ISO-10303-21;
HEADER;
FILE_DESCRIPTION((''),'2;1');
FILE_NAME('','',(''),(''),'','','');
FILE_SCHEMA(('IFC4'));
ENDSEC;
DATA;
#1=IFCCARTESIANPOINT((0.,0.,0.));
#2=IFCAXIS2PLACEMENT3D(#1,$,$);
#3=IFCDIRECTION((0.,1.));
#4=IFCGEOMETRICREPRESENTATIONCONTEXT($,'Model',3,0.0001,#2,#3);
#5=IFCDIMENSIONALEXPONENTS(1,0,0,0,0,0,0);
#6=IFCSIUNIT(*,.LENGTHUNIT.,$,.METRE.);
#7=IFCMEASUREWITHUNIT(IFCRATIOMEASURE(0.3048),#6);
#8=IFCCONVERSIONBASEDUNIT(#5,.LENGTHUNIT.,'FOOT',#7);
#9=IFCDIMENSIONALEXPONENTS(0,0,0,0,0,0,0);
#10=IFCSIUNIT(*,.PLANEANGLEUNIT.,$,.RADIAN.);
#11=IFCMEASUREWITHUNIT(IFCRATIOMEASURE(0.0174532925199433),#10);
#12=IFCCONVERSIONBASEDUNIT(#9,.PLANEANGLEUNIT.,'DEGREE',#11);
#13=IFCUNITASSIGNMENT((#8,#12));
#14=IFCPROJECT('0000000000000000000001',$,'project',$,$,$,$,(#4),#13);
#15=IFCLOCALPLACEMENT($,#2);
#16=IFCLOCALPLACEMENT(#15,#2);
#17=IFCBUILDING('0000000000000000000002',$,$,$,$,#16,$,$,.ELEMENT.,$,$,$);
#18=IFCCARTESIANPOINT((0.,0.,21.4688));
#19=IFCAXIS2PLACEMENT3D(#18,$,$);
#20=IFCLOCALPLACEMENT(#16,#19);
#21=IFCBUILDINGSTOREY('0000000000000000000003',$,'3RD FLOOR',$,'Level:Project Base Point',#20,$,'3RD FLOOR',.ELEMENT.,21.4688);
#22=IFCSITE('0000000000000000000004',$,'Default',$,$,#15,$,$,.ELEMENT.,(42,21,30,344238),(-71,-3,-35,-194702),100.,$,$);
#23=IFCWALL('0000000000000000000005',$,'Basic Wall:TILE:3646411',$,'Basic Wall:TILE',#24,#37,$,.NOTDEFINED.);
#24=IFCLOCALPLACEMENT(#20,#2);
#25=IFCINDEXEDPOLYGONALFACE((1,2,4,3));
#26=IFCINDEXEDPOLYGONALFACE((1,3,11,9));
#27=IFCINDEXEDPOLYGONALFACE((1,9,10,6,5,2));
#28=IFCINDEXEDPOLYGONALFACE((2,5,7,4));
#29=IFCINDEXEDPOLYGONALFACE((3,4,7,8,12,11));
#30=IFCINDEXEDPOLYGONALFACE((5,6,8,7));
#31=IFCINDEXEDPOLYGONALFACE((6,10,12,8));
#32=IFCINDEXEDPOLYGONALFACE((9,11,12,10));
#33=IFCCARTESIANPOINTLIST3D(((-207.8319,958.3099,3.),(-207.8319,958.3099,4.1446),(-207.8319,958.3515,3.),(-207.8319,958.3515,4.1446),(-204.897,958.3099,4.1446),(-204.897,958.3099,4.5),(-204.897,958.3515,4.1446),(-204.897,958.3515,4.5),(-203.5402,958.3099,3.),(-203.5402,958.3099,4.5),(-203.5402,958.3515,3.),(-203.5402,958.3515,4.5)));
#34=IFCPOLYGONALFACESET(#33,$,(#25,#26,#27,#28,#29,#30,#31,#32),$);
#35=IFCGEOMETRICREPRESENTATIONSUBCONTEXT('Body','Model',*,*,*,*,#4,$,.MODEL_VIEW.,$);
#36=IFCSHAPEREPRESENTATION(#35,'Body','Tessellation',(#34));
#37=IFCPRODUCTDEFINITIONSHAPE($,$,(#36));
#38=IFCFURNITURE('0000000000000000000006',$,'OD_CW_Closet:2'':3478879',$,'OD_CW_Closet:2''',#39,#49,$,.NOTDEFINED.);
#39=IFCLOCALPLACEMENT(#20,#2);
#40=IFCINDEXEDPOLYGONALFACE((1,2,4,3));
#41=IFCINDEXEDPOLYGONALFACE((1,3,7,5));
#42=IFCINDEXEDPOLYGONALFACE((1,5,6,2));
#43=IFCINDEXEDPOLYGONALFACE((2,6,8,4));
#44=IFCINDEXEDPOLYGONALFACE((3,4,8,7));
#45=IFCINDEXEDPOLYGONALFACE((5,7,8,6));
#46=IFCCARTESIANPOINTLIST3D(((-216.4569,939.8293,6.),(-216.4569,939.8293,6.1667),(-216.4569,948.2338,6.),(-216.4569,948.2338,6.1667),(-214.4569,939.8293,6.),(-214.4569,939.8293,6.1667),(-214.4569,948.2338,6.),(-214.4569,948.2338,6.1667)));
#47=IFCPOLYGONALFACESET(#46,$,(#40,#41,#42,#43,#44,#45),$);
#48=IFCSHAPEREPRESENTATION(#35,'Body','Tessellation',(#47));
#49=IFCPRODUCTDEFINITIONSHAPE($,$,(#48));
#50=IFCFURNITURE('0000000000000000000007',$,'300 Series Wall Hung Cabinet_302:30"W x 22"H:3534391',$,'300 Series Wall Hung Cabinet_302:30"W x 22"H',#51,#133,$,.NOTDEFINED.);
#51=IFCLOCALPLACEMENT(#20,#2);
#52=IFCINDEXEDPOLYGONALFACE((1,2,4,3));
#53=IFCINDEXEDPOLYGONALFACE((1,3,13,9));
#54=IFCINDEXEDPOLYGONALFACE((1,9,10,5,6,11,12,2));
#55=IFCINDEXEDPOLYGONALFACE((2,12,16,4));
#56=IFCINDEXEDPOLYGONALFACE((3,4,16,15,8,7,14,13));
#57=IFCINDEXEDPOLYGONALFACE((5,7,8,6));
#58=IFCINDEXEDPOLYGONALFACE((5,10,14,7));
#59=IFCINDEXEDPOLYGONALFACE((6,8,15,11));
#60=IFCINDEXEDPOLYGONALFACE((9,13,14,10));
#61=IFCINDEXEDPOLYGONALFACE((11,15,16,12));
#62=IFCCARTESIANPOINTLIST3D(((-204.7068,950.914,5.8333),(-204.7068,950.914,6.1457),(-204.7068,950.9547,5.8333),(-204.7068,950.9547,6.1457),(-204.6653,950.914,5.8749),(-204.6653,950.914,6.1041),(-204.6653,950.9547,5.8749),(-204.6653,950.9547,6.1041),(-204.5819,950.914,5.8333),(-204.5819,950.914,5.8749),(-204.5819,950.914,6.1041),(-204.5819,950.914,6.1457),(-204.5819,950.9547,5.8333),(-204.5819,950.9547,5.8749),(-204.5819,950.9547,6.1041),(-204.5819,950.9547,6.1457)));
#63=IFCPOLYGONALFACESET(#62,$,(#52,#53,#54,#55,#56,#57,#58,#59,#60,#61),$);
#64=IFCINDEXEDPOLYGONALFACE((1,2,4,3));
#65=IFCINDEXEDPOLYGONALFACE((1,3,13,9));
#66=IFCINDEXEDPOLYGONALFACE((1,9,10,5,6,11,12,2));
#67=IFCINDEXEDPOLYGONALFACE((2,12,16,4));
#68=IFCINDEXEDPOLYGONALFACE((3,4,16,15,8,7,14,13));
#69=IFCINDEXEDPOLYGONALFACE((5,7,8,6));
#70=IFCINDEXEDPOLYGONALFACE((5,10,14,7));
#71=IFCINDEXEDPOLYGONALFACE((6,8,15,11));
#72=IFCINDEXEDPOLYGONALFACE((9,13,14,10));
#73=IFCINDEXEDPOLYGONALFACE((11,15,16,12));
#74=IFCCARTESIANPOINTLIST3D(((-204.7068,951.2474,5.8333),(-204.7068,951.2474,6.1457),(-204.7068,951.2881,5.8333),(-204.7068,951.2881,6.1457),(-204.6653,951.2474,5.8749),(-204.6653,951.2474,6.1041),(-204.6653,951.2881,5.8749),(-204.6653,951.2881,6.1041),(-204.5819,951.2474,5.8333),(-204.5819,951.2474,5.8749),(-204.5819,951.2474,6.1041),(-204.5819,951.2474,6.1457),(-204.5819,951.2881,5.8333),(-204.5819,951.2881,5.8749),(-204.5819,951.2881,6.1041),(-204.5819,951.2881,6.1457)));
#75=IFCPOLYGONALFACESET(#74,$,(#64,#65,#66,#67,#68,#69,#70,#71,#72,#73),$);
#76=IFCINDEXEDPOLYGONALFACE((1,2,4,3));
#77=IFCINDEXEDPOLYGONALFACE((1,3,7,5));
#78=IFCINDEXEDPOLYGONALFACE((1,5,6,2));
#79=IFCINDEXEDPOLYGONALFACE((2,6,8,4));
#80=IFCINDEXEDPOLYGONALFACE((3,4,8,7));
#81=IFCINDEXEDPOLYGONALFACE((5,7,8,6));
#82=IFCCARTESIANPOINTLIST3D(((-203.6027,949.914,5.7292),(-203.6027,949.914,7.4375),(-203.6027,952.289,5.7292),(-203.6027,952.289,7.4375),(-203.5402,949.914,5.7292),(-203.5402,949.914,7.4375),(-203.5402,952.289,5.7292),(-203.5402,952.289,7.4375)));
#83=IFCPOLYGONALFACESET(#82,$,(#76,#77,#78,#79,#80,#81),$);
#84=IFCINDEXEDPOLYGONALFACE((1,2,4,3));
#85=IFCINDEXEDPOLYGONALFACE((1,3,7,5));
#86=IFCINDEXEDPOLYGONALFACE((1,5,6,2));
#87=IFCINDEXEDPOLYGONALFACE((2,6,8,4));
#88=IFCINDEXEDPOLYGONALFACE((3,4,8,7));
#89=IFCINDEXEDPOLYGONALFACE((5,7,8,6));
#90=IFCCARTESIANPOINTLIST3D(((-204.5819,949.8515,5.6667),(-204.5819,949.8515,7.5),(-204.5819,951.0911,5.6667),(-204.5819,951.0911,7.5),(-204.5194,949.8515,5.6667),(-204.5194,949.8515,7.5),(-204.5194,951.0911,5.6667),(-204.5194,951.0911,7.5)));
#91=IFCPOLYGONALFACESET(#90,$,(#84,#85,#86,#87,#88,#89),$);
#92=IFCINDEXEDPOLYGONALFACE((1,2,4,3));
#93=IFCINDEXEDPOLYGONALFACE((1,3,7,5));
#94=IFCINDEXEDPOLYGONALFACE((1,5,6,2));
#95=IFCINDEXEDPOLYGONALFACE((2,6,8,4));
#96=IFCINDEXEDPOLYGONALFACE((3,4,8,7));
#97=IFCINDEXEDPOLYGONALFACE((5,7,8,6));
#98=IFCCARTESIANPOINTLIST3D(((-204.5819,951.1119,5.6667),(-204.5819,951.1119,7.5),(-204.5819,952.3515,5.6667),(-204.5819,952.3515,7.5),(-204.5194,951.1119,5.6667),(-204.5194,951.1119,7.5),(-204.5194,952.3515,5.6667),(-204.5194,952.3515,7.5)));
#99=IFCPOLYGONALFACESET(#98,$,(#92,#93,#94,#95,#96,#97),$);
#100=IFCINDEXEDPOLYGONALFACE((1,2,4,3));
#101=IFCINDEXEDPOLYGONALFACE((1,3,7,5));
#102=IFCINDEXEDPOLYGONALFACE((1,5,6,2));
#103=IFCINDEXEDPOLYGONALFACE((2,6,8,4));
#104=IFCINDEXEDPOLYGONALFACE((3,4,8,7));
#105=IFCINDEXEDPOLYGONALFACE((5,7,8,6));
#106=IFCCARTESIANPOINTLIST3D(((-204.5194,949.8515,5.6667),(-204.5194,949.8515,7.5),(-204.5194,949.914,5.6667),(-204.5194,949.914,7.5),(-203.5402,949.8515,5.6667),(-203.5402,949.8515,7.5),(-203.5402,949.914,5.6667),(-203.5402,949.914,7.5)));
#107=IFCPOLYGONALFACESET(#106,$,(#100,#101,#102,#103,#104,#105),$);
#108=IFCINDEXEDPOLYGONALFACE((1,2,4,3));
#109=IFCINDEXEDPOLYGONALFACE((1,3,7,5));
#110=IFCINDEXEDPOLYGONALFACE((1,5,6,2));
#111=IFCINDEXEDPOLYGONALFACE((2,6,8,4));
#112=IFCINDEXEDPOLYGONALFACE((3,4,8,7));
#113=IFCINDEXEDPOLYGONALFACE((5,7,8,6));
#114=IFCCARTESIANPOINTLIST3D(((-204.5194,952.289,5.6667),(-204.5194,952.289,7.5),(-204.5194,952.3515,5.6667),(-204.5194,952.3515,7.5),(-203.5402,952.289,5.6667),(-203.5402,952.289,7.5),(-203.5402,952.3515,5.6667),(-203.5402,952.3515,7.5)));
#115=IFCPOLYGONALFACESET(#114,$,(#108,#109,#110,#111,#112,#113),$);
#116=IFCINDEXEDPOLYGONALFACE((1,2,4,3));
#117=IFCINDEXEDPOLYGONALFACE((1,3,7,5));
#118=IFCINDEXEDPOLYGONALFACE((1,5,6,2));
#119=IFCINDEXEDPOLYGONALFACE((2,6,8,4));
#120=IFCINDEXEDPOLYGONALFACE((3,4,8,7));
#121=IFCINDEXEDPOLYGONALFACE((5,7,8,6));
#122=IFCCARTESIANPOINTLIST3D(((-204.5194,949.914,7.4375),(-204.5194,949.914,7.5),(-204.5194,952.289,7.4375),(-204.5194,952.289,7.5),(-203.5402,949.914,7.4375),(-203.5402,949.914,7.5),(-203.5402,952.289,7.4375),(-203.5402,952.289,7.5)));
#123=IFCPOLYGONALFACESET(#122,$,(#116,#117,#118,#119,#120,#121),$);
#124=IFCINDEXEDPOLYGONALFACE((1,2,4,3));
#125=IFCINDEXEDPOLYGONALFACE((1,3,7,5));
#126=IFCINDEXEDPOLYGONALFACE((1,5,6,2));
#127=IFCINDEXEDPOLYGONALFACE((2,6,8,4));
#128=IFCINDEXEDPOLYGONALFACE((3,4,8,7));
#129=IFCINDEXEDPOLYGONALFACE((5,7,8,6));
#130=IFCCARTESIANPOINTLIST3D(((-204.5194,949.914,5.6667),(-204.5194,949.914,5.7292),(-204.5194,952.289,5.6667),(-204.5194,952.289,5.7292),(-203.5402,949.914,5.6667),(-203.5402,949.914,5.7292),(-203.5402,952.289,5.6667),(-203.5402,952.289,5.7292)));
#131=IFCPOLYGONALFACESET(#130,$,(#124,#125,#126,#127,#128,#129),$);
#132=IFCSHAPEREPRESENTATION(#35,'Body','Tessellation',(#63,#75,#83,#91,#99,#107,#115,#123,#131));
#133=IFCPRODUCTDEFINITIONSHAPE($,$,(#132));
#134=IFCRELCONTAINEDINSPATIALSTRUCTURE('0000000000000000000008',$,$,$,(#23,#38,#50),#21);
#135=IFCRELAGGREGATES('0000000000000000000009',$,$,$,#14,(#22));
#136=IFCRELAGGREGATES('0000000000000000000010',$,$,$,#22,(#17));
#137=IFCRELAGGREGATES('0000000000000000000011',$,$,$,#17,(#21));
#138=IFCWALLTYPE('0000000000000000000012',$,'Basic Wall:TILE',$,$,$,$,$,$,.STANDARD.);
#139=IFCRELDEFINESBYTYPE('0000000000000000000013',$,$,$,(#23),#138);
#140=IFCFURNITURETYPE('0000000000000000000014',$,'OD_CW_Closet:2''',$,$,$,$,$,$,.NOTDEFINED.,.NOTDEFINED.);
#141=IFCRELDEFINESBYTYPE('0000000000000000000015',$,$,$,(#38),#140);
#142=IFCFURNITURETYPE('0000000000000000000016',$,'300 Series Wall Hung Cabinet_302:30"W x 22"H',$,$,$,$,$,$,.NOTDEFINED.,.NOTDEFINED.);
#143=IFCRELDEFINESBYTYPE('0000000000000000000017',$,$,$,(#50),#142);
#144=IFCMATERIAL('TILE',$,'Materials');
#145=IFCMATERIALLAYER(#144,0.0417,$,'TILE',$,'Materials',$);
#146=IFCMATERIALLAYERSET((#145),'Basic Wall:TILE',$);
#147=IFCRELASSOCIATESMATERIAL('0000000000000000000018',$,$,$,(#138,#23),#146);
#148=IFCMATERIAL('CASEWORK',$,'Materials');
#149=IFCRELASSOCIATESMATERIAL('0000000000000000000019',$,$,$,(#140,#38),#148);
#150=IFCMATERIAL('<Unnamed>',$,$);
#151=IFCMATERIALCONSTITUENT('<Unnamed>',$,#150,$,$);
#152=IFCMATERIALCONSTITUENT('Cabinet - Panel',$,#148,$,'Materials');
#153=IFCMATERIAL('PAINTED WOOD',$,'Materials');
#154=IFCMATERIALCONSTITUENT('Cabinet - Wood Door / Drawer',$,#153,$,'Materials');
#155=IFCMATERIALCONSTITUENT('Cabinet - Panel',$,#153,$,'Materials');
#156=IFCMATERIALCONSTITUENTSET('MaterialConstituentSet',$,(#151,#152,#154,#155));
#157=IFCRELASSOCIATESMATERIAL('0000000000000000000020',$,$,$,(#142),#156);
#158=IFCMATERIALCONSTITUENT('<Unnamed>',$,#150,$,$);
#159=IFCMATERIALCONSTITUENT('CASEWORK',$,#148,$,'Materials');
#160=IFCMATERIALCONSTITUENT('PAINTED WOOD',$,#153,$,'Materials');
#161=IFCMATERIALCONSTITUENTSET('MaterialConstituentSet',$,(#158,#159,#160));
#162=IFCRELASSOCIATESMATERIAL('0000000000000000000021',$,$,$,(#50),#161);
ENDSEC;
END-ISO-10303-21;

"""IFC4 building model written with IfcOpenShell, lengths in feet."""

from ifc_helpers import new_model, entity, si_unit, converted_unit, direction, frame, frame_2d, origin, origin_2d_with_axis, place, context, subcontext, project, spatial, polyline, rectangle, outline, extrude, source, transform, mapped, material, layer, layer_set, layer_usage, constituent, constituent_set, type_object, type_shapes, element, save


model = new_model("IFC4")

# Units and contexts
model_context = context("Model", 3, precision=0.0001, world=origin(), true_north=direction((0.0, 1.0)))
body_context = subcontext(model_context, "Body", "Model", "MODEL_VIEW")
ifc_project = project(units=[converted_unit("LENGTHUNIT", "FOOT", entity("IfcRatioMeasure", 0.3048), si_unit("LENGTHUNIT", "METRE"), dimensions=[1, 0, 0, 0, 0, 0, 0]), converted_unit("PLANEANGLEUNIT", "DEGREE", entity("IfcRatioMeasure", 0.0174532925199433), si_unit("PLANEANGLEUNIT", "RADIAN"), dimensions=[0, 0, 0, 0, 0, 0, 0])], contexts=[model_context])

# Site, building, storey
site_placement = place(None, origin())
site = spatial("IfcSite", under=ifc_project, at=site_placement, Name="Default", CompositionType="ELEMENT", RefLatitude=(42, 21, 30, 344238), RefLongitude=(-71, -3, -35, -194702), RefElevation=100.0)
building_placement = place(site_placement, origin())
building = spatial("IfcBuilding", under=site, at=building_placement, CompositionType="ELEMENT")
storey_placement = place(building_placement, frame((0.0, 0.0, 21.4688)))
storey = spatial("IfcBuildingStorey", under=building, at=storey_placement, Name="3RD FLOOR", ObjectType="Level:Project Base Point", LongName="3RD FLOOR", CompositionType="ELEMENT", Elevation=21.4688)

# Shared definitions
ifc_material_1 = material(Name="TILE", Category="Materials")
ifc_layer_1 = layer(ifc_material_1, 0.0417, Name="TILE", Category="Materials")
ifc_layer_set_1 = layer_set([ifc_layer_1], Name="Basic Wall:TILE")
wall_type_1 = type_object("IfcWallType", Name="Basic Wall:TILE", PredefinedType="STANDARD", material=ifc_layer_set_1)

# Wall, opening
ifc_layer_usage_1 = layer_usage(ifc_layer_set_1, "AXIS2", "POSITIVE", -0.0208)
wall_1_placement = place(storey_placement, frame((-203.5402, 958.3307, 3.0), z_axis=(0.0, 0.0, 1.0), x_axis=(-1.0, 0.0, 0.0)))
wall_1 = element("IfcWall", 1, at=wall_1_placement, inside=storey, type_object=wall_type_1, material=ifc_layer_usage_1, Name="Basic Wall:TILE:3646411", ObjectType="Basic Wall:TILE", PredefinedType="NOTDEFINED", context=body_context, shape_type="SweptSolid", body=[
    extrude(rectangle(XDim=4.2917, YDim=0.0417, at=frame_2d((2.1458, 0.0), x_axis=(-1.0, 0.0))), origin(), (0.0, 0.0, 1.0), 1.5),
])
opening_1_placement = place(wall_1_placement, origin())
element("IfcOpeningElement", 2, at=opening_1_placement, cuts=wall_1, PredefinedType="OPENING", context=body_context, shape_type="SweptSolid", body=[
    extrude(rectangle(XDim=0.3554, YDim=2.9349, at=frame_2d((0.0, 0.0), x_axis=(1.0, 0.0))), frame((2.8242, 0.0208, 1.3223), z_axis=(0.0, -1.0, 0.0), x_axis=(0.0, 0.0, 1.0)), (0.0, 0.0, 1.0), 0.0417),
])

# Furniture
ifc_material_2 = material(Name="CASEWORK", Category="Materials")
furniture_type_1 = type_object("IfcFurnitureType", Name="OD_CW_Closet:2'", AssemblyPlace="NOTDEFINED", PredefinedType="NOTDEFINED", material=ifc_material_2)
shared_shape_1 = source(origin(), body_context, "Body", "SweptSolid", [
    extrude(rectangle(XDim=2.0, YDim=8.4045, at=frame_2d((0.0, 0.0), x_axis=(1.0, 0.0))), frame((4.2022, 1.0, 0.0), z_axis=(0.0, 0.0, 1.0), x_axis=(0.0, -1.0, 0.0)), (0.0, 0.0, 1.0), 0.1667),
])
type_shapes(furniture_type_1, [shared_shape_1])
furniture_1_placement = place(storey_placement, frame((-216.4569, 948.2338, 6.0), z_axis=(0.0, 0.0, 1.0), x_axis=(0.0, -1.0, 0.0)))
element("IfcFurniture", 3, at=furniture_1_placement, inside=storey, type_object=furniture_type_1, material=ifc_material_2, Name="OD_CW_Closet:2':3478879", ObjectType="OD_CW_Closet:2'", PredefinedType="NOTDEFINED", context=body_context, shape_type="MappedRepresentation", body=[
    mapped(shared_shape_1, transform((0.0, 0.0, 0.0), scale=1.0)),
])
ifc_material_3 = material(Name="<Unnamed>")
ifc_constituent_1 = constituent(ifc_material_3, Name="<Unnamed>")
ifc_constituent_2 = constituent(ifc_material_2, Name="CASEWORK", Category="Materials")
ifc_material_4 = material(Name="PAINTED WOOD", Category="Materials")
ifc_constituent_3 = constituent(ifc_material_4, Name="PAINTED WOOD", Category="Materials")
ifc_constituent_set_1 = constituent_set(constituents=[ifc_constituent_1, ifc_constituent_2, ifc_constituent_3], Name="MaterialConstituentSet")
ifc_constituent_4 = constituent(ifc_material_3, Name="<Unnamed>")
ifc_constituent_5 = constituent(ifc_material_2, Name="Cabinet - Panel", Category="Materials")
ifc_constituent_6 = constituent(ifc_material_4, Name="Cabinet - Wood Door / Drawer", Category="Materials")
ifc_constituent_7 = constituent(ifc_material_4, Name="Cabinet - Panel", Category="Materials")
ifc_constituent_set_2 = constituent_set(constituents=[ifc_constituent_4, ifc_constituent_5, ifc_constituent_6, ifc_constituent_7], Name="MaterialConstituentSet")
furniture_type_2 = type_object("IfcFurnitureType", Name="300 Series Wall Hung Cabinet_302:30\"W x 22\"H", AssemblyPlace="NOTDEFINED", PredefinedType="NOTDEFINED", material=ifc_constituent_set_2)
shared_shape_2 = source(origin(), body_context, "Body", "SweptSolid", [
    extrude(outline(polyline([(-0.0521, -0.1146), (-0.0521, -0.1562), (0.0729, -0.1562), (0.0729, 0.1562), (-0.0521, 0.1562), (-0.0521, 0.1146), (0.0313, 0.1146), (0.0313, -0.1146), (-0.0521, -0.1146)])), frame((1.0625, 1.0937, 0.3229), z_axis=(-1.0, 0.0, 0.0), x_axis=(0.0, 1.0, 0.0)), (0.0, 0.0, -1.0), 0.0407),
    extrude(outline(polyline([(-0.0521, -0.1146), (-0.0521, -0.1562), (0.0729, -0.1562), (0.0729, 0.1562), (-0.0521, 0.1562), (-0.0521, 0.1146), (0.0313, 0.1146), (0.0313, -0.1146), (-0.0521, -0.1146)])), frame((1.3958, 1.0937, 0.3229), z_axis=(-1.0, 0.0, 0.0), x_axis=(0.0, 1.0, 0.0)), (0.0, 0.0, -1.0), 0.0407),
    extrude(rectangle(XDim=0.0625, YDim=2.375, at=frame_2d((0.0, 0.0), x_axis=(1.0, 0.0))), frame((1.25, 0.0313, 0.0625), z_axis=(0.0, 0.0, 1.0), x_axis=(0.0, 1.0, 0.0)), (0.0, 0.0, 1.0), 1.7083),
    extrude(rectangle(XDim=0.0625, YDim=1.2396, at=origin_2d_with_axis()), frame((0.6198, 1.0104, 0.0), z_axis=(0.0, 0.0, 1.0), x_axis=(0.0, 1.0, 0.0)), (0.0, 0.0, 1.0), 1.8333),
    extrude(rectangle(XDim=0.0625, YDim=1.2396, at=frame_2d((0.0, 0.0), x_axis=(1.0, 0.0))), frame((1.8802, 1.0104, 0.0), z_axis=(0.0, 0.0, 1.0), x_axis=(0.0, 1.0, 0.0)), (0.0, 0.0, 1.0), 1.8333),
    extrude(rectangle(XDim=0.0625, YDim=0.9792, at=frame_2d((0.0, 0.0), x_axis=(1.0, 0.0))), frame((0.0313, 0.4896, 0.0)), (0.0, 0.0, 1.0), 1.8333),
    extrude(rectangle(XDim=0.0625, YDim=0.9792, at=frame_2d((0.0, 0.0), x_axis=(1.0, 0.0))), frame((2.4688, 0.4896, 0.0)), (0.0, 0.0, 1.0), 1.8333),
    extrude(rectangle(XDim=2.375, YDim=0.9792, at=frame_2d((0.0, 0.0), x_axis=(1.0, 0.0))), frame((1.25, 0.4896, 1.7708), z_axis=(0.0, 0.0, 1.0), x_axis=(-1.0, 0.0, 0.0)), (0.0, 0.0, 1.0), 0.0625),
    extrude(rectangle(XDim=2.375, YDim=0.9792, at=frame_2d((0.0, 0.0), x_axis=(1.0, 0.0))), frame((1.25, 0.4896, 0.0), z_axis=(0.0, 0.0, 1.0), x_axis=(-1.0, 0.0, 0.0)), (0.0, 0.0, 1.0), 0.0625),
])
type_shapes(furniture_type_2, [shared_shape_2])
furniture_2_placement = place(storey_placement, frame((-203.5402, 949.8515, 5.6667), z_axis=(0.0, 0.0, 1.0), x_axis=(0.0, 1.0, 0.0)))
element("IfcFurniture", 4, at=furniture_2_placement, inside=storey, type_object=furniture_type_2, material=ifc_constituent_set_1, Name="300 Series Wall Hung Cabinet_302:30\"W x 22\"H:3534391", ObjectType="300 Series Wall Hung Cabinet_302:30\"W x 22\"H", PredefinedType="NOTDEFINED", context=body_context, shape_type="MappedRepresentation", body=[
    mapped(shared_shape_2, transform((0.0, 0.0, 0.0), scale=1.0)),
])

save(model, "model.ifc")
